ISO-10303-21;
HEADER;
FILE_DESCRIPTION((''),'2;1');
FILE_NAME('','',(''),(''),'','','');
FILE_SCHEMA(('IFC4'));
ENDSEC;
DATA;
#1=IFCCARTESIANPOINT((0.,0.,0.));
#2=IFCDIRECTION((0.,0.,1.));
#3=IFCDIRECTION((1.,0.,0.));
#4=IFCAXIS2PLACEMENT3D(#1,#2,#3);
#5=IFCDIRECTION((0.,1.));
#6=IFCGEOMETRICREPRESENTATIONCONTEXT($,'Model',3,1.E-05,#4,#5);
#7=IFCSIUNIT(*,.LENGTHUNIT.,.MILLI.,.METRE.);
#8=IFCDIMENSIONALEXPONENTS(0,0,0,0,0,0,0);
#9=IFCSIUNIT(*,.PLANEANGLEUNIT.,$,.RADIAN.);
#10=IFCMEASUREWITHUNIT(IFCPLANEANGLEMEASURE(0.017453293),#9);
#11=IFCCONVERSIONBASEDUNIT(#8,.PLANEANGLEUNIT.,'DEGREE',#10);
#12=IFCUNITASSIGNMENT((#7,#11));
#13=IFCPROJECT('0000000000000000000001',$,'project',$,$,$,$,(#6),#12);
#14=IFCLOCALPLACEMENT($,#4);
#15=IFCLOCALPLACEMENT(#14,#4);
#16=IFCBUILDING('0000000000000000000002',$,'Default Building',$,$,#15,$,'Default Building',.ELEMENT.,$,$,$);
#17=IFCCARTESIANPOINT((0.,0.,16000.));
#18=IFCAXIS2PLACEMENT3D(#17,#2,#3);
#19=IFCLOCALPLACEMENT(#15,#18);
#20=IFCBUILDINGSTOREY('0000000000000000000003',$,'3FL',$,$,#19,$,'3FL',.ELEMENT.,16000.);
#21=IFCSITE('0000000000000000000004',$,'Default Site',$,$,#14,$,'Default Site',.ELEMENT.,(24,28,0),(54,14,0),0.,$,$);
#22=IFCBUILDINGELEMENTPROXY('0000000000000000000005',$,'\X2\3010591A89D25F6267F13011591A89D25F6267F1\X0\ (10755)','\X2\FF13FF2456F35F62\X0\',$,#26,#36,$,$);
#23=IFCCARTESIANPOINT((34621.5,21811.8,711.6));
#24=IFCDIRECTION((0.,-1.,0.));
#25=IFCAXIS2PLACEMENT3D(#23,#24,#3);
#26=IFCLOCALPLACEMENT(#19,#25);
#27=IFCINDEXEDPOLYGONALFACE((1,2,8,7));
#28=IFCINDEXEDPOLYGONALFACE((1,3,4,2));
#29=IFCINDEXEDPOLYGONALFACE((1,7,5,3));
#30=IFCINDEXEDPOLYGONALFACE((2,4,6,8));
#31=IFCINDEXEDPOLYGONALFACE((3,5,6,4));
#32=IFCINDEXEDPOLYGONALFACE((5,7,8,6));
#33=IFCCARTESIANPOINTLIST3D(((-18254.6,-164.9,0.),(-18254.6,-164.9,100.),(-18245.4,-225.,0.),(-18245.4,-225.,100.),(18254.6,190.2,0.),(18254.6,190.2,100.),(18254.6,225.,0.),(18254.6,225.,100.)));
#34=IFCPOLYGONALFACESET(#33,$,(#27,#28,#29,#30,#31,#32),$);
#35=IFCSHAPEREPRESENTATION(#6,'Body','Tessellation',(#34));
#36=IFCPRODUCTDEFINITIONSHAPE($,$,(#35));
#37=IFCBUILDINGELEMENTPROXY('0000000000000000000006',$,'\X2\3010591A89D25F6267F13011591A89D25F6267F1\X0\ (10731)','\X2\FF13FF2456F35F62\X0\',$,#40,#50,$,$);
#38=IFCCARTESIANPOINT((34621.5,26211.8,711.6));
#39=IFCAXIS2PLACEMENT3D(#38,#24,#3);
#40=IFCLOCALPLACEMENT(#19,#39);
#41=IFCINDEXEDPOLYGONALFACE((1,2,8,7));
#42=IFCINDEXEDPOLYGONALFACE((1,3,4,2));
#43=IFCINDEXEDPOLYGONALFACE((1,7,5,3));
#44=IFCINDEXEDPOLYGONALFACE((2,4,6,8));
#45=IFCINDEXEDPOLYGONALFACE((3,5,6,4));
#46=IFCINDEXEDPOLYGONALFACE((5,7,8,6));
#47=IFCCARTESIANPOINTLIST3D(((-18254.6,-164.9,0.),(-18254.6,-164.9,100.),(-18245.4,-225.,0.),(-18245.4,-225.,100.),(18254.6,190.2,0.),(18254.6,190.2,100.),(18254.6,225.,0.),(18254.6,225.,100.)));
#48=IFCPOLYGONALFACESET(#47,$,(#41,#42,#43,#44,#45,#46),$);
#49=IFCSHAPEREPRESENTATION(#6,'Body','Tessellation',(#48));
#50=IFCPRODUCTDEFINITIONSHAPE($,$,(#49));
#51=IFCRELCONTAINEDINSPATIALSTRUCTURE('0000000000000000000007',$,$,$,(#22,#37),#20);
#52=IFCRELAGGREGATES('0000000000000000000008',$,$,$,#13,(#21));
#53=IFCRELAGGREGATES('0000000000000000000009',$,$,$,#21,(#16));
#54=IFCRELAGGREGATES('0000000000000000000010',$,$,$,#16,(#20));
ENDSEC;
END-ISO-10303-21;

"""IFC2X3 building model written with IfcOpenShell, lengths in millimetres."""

from ifc_helpers import new_model, entity, si_unit, converted_unit, direction, frame, origin_with_axes, place, context, project, spatial, polyline, outline, extrude, source, transform, mapped, element, save


model = new_model("IFC2X3")

# Units and contexts
model_context = context("Model", 3, precision=1e-05, world=origin_with_axes(), true_north=direction((0.0, 1.0)))
ifc_project = project(units=[si_unit("LENGTHUNIT", "METRE", prefix="MILLI"), converted_unit("PLANEANGLEUNIT", "DEGREE", entity("IfcPlaneAngleMeasure", 0.017453293), si_unit("PLANEANGLEUNIT", "RADIAN"), dimensions=[0, 0, 0, 0, 0, 0, 0])], contexts=[model_context])

# Site, building, storey
site_placement = place(None, origin_with_axes())
site = spatial("IfcSite", under=ifc_project, at=site_placement, Name="Default Site", LongName="Default Site", CompositionType="ELEMENT", RefLatitude=(24, 28, 0), RefLongitude=(54, 14, 0), RefElevation=0.0)
building_placement = place(site_placement, origin_with_axes())
building = spatial("IfcBuilding", under=site, at=building_placement, Name="Default Building", LongName="Default Building", CompositionType="ELEMENT")
storey_placement = place(building_placement, frame((0.0, 0.0, 16000.0), z_axis=(0.0, 0.0, 1.0), x_axis=(1.0, 0.0, 0.0)))
storey = spatial("IfcBuildingStorey", under=building, at=storey_placement, Name="3FL", LongName="3FL", CompositionType="ELEMENT", Elevation=16000.0)

# Building element proxies
shared_shape_1 = source(origin_with_axes(), model_context, "Body", "SweptSolid", [
    extrude(outline(polyline([(-18245.4, -225.0), (18254.6, 190.2), (18254.6, 225.0), (-18254.6, -164.9), (-18245.4, -225.0)])), origin_with_axes(), (0.0, 0.0, 1.0), 100.0),
])
proxy_1_placement = place(storey_placement, frame((34621.5, 21811.8, 711.6), z_axis=(0.0, -1.0, 0.0), x_axis=(1.0, 0.0, 0.0)))
element("IfcBuildingElementProxy", 1, at=proxy_1_placement, inside=storey, Name="【多角形柱】多角形柱 (10755)", Description="３Ｄ図形", context=model_context, shape_type="MappedRepresentation", body=[
    mapped(shared_shape_1, transform((0.0, 0.0, 0.0))),
])
shared_shape_2 = source(origin_with_axes(), model_context, "Body", "SweptSolid", [
    extrude(outline(polyline([(-18245.4, -225.0), (18254.6, 190.2), (18254.6, 225.0), (-18254.6, -164.9), (-18245.4, -225.0)])), origin_with_axes(), (0.0, 0.0, 1.0), 100.0),
])
proxy_2_placement = place(storey_placement, frame((34621.5, 26211.8, 711.6), z_axis=(0.0, -1.0, 0.0), x_axis=(1.0, 0.0, 0.0)))
element("IfcBuildingElementProxy", 2, at=proxy_2_placement, inside=storey, Name="【多角形柱】多角形柱 (10731)", Description="３Ｄ図形", context=model_context, shape_type="MappedRepresentation", body=[
    mapped(shared_shape_2, transform((0.0, 0.0, 0.0))),
])

save(model, "model.ifc")
